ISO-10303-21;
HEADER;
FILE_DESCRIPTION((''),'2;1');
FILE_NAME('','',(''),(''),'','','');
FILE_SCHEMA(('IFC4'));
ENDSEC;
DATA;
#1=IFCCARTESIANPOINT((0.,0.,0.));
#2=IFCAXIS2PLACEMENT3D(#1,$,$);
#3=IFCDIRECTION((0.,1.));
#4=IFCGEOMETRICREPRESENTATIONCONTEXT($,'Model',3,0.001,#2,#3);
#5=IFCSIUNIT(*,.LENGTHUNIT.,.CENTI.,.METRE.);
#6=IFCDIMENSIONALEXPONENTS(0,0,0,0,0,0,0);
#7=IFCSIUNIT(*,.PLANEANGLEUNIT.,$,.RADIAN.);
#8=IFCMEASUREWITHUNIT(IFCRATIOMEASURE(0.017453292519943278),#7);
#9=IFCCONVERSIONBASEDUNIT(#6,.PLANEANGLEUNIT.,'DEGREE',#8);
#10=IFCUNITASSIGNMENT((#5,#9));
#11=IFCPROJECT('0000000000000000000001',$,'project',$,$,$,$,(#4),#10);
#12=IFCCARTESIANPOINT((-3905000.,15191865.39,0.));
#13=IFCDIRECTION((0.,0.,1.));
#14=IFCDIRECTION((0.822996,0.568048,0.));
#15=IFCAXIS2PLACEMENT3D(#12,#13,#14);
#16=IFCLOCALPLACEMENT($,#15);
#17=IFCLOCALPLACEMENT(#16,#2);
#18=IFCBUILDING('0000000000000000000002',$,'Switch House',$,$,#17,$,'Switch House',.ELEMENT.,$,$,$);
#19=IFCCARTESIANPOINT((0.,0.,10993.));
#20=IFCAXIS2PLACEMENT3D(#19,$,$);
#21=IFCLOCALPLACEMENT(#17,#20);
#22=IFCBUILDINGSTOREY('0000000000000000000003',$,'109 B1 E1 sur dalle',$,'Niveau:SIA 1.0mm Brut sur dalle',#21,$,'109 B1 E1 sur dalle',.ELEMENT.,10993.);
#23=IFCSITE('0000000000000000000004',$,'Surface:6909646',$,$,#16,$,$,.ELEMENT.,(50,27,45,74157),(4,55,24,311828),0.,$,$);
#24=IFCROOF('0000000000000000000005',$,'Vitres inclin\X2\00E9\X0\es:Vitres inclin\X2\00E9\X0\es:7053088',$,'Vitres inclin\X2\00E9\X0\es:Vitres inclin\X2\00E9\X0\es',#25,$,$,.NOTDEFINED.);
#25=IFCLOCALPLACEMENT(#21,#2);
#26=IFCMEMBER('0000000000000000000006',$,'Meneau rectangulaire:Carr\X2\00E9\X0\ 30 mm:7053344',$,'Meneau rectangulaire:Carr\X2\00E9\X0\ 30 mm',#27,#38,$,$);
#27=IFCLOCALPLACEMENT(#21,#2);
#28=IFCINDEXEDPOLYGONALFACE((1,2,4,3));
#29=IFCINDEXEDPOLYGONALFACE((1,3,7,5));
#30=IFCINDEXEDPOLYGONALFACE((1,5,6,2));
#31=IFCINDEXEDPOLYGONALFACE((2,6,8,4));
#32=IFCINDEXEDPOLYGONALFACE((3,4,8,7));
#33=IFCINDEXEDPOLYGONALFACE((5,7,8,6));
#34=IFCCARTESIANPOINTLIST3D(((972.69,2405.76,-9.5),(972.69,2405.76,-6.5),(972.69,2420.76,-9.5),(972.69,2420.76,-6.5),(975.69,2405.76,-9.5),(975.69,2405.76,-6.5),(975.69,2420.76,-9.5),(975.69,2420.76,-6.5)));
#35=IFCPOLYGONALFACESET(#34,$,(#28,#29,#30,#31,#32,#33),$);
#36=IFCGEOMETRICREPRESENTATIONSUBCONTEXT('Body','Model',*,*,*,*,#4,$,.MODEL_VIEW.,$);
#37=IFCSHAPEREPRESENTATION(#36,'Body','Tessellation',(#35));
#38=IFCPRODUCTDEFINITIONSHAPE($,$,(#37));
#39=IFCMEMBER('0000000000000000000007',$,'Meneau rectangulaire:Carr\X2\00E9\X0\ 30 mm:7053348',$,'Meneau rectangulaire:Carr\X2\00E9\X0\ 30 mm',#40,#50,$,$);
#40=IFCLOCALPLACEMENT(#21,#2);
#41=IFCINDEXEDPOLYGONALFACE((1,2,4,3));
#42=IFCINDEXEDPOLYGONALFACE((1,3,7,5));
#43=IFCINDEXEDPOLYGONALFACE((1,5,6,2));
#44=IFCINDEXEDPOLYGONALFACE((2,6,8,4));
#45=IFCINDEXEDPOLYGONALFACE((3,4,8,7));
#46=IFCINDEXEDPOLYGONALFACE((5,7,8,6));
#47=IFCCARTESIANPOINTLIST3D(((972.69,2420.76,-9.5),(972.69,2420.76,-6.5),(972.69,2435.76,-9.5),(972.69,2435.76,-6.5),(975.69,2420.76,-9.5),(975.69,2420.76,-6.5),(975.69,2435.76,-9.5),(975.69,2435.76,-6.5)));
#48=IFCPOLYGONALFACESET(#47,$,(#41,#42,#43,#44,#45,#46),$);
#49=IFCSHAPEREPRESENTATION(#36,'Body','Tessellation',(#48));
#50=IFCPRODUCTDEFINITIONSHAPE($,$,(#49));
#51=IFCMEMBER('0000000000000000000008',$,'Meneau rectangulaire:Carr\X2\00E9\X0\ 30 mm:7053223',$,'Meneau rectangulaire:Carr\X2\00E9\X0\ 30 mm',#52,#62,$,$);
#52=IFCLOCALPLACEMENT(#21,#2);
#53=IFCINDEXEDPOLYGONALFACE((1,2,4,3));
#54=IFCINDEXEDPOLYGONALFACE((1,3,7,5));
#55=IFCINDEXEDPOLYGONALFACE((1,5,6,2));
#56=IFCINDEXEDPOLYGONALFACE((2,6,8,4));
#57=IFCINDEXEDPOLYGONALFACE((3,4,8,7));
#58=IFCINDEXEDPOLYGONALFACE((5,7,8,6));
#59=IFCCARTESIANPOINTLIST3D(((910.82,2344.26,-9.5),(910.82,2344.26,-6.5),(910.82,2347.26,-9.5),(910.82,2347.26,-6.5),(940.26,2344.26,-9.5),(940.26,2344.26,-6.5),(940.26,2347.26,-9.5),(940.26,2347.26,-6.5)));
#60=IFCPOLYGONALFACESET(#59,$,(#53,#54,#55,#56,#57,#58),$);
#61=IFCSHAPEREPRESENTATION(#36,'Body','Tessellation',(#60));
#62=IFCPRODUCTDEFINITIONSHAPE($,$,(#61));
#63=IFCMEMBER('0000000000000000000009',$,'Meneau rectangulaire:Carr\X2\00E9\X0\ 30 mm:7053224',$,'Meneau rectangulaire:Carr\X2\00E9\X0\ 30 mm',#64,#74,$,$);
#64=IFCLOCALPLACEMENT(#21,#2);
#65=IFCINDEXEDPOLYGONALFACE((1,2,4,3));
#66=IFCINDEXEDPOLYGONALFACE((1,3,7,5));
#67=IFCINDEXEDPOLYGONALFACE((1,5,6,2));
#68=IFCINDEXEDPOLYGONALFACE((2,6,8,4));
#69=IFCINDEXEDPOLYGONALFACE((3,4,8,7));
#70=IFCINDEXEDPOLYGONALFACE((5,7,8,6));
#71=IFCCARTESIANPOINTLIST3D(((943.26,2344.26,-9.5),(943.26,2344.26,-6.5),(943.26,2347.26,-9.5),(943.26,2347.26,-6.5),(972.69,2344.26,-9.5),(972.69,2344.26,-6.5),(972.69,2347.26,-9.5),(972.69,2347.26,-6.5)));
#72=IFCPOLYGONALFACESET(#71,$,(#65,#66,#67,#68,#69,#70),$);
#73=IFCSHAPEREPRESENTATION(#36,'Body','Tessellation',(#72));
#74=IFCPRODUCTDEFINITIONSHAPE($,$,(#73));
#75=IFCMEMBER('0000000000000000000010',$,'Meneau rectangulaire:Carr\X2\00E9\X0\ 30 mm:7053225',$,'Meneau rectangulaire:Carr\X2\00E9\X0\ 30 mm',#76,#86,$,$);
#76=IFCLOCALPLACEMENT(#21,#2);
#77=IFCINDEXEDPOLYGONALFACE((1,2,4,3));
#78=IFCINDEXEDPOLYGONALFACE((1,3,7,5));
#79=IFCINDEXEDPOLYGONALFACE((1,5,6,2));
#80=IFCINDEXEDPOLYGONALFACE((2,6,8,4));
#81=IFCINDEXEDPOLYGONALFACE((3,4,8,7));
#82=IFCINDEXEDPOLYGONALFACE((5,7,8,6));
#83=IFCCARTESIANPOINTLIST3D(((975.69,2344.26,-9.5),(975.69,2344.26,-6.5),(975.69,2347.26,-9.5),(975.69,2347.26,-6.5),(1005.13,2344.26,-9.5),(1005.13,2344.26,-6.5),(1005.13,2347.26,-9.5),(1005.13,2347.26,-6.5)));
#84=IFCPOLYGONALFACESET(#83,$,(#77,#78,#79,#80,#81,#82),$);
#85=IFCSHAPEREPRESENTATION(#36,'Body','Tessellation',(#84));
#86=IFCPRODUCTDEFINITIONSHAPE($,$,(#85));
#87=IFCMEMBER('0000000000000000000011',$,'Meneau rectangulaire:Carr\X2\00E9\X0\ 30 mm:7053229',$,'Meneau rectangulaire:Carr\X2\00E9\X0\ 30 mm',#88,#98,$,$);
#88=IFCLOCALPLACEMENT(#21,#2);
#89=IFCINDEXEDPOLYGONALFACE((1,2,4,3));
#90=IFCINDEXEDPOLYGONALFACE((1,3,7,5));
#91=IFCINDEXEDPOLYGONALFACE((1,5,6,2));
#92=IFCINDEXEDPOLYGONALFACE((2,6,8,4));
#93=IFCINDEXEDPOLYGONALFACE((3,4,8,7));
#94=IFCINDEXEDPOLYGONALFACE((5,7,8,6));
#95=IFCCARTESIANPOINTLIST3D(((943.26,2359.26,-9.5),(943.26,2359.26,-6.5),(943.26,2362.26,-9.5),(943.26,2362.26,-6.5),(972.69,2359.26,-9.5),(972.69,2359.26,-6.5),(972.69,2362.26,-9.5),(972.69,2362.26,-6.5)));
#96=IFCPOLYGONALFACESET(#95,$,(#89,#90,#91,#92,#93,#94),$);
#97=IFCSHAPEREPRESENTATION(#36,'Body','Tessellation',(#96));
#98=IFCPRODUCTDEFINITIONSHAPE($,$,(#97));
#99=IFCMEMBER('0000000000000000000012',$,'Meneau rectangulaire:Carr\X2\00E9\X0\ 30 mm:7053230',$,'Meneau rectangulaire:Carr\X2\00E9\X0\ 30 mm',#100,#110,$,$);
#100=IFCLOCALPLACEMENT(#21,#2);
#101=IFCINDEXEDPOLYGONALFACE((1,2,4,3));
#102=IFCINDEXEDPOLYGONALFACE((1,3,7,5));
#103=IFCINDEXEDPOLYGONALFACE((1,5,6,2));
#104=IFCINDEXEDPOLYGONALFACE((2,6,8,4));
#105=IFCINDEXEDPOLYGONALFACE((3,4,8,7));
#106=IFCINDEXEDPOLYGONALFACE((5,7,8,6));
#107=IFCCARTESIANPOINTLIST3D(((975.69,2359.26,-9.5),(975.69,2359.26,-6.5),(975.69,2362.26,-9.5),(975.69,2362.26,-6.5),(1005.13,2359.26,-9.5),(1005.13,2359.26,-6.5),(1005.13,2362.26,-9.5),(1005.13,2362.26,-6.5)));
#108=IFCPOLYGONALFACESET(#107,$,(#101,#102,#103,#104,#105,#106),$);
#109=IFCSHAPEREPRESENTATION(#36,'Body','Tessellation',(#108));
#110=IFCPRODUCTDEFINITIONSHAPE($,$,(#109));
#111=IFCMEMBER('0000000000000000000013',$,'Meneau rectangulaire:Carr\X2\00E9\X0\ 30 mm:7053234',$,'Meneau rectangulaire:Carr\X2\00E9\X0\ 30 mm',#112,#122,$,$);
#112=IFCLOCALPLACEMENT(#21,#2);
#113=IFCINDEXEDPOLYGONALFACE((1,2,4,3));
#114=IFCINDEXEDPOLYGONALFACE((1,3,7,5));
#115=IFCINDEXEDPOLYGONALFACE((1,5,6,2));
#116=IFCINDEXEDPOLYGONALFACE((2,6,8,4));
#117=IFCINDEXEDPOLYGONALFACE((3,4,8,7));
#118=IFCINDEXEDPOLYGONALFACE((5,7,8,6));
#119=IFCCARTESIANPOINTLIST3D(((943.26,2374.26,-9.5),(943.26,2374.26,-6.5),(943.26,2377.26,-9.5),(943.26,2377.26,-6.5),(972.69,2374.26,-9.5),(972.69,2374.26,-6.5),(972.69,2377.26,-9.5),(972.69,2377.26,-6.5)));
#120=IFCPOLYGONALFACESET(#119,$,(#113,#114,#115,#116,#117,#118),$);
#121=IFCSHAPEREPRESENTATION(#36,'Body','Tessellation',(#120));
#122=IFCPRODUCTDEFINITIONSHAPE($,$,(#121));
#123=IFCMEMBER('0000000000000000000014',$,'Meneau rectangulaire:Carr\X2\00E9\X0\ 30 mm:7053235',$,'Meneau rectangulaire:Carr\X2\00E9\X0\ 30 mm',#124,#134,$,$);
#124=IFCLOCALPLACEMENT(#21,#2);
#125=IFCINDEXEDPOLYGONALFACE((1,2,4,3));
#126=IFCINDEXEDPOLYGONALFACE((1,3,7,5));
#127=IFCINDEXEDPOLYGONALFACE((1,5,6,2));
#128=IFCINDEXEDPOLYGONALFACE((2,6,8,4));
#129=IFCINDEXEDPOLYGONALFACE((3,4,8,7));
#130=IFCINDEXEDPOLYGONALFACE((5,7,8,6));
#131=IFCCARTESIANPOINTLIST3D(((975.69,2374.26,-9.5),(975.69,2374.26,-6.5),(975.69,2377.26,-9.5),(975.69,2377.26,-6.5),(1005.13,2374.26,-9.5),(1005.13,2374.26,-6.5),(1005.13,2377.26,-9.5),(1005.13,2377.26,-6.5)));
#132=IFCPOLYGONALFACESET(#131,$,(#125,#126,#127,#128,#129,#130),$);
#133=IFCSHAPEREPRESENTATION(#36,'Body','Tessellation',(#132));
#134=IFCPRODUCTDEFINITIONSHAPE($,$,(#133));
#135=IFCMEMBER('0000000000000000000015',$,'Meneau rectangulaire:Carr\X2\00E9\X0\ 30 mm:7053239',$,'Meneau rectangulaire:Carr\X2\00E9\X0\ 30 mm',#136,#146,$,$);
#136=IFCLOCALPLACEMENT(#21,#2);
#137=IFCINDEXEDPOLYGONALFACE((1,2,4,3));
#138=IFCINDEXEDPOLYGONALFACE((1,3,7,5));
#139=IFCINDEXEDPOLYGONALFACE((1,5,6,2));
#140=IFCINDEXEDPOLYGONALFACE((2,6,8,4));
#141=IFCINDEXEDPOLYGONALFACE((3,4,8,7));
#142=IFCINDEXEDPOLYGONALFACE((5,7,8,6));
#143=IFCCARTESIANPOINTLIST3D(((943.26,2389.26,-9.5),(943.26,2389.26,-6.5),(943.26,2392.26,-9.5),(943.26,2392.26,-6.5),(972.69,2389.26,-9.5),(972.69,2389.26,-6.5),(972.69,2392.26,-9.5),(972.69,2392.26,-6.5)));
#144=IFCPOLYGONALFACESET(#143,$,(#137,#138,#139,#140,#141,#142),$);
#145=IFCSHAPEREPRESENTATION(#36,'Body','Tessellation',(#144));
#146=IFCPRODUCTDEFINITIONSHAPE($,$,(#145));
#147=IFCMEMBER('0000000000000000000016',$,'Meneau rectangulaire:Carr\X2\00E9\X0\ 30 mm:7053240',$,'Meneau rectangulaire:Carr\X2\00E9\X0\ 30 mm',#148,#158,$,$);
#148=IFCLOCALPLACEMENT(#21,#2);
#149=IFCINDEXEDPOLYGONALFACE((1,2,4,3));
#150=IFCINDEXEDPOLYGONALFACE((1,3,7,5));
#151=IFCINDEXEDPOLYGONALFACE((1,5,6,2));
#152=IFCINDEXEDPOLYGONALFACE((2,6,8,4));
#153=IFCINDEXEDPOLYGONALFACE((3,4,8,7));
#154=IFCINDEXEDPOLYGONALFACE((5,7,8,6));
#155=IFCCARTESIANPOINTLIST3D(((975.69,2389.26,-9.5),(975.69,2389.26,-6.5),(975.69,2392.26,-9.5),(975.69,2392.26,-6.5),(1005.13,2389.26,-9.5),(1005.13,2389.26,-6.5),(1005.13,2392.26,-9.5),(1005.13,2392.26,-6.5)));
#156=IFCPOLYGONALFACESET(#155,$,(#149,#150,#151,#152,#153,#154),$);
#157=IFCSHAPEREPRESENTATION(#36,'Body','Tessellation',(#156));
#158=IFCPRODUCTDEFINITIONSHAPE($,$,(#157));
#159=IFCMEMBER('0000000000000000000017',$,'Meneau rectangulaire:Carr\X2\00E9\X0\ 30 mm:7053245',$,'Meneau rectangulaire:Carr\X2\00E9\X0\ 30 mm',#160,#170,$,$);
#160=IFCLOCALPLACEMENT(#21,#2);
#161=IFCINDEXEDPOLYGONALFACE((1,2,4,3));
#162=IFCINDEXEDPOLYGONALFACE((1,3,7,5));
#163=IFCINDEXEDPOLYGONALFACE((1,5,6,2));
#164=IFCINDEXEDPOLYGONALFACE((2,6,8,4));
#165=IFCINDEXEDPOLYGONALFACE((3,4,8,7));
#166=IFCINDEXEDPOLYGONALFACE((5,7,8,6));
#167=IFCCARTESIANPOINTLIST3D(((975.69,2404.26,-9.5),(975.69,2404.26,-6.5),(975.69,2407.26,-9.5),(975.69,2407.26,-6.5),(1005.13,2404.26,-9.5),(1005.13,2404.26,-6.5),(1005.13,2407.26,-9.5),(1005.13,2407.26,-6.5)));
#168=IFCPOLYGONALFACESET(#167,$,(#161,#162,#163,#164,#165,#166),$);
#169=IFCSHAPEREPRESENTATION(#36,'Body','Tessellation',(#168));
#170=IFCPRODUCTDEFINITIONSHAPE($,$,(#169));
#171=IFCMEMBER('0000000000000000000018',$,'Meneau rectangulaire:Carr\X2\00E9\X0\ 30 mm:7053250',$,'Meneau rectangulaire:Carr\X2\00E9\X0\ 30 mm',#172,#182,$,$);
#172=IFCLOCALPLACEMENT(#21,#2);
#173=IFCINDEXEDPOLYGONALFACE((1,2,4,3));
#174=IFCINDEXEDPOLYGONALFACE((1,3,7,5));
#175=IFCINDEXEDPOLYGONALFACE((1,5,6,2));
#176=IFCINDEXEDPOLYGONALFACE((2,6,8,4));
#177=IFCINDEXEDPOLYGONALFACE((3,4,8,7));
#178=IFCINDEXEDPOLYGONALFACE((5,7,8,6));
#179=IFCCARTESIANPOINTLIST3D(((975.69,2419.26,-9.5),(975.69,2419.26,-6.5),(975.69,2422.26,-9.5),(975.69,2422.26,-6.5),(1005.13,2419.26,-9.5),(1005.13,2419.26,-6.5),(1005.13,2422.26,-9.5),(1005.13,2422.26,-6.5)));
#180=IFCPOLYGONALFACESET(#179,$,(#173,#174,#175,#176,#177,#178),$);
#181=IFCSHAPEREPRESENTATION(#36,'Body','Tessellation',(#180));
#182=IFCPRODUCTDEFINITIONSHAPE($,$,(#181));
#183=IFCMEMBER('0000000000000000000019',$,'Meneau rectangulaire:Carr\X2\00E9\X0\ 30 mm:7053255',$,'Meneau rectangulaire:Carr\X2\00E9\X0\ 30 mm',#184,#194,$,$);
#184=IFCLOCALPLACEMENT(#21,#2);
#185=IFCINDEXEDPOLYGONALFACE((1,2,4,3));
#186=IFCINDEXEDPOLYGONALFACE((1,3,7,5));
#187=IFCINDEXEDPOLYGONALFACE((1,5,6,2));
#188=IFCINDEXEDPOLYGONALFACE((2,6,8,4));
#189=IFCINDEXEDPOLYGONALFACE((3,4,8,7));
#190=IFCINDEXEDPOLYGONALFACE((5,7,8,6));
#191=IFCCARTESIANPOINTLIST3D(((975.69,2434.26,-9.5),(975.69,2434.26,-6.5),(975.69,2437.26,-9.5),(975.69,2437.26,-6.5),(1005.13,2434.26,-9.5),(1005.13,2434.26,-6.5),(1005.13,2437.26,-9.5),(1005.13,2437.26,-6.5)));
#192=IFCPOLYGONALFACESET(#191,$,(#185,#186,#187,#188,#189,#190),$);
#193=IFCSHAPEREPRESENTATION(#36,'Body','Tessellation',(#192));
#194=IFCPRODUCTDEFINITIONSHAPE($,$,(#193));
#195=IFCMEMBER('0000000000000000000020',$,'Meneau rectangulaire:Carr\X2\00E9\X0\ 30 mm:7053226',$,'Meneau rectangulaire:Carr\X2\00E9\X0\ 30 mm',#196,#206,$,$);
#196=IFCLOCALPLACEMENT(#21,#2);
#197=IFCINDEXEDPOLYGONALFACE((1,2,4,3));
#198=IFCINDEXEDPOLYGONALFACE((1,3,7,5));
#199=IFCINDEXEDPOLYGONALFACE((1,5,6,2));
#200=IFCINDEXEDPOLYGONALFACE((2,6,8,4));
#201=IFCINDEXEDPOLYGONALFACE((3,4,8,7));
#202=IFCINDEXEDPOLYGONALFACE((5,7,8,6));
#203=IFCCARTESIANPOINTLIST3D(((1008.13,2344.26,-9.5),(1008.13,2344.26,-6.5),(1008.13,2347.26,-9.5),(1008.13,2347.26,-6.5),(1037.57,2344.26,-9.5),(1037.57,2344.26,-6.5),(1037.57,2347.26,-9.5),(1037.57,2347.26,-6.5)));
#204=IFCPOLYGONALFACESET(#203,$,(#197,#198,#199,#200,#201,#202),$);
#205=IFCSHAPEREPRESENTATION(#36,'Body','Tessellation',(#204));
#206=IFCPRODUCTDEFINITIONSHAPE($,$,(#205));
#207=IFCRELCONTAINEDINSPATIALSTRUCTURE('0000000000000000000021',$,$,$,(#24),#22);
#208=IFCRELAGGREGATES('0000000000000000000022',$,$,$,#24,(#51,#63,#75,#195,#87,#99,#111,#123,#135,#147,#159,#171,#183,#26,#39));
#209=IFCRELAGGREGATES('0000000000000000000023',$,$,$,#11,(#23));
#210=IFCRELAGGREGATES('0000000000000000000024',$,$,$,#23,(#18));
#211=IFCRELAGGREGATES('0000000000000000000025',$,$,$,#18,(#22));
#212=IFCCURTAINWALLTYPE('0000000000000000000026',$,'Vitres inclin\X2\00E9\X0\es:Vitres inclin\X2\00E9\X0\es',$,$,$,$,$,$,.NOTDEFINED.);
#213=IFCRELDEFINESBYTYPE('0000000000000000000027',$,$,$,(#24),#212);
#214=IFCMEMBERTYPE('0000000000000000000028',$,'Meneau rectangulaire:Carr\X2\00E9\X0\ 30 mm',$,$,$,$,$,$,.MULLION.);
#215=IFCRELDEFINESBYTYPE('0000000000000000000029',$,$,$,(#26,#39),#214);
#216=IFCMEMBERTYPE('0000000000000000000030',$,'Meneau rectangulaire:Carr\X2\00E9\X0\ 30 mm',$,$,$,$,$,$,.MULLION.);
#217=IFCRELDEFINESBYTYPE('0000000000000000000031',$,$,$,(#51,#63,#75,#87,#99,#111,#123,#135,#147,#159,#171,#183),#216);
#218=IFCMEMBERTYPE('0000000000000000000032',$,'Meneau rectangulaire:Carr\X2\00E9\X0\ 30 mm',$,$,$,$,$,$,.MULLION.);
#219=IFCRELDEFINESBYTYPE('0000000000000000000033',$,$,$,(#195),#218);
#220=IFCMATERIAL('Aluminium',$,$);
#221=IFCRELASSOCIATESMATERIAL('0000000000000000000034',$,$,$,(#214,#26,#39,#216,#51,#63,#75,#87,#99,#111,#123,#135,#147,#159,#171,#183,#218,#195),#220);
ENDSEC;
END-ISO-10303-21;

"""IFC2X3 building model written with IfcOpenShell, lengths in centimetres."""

from ifc_helpers import new_model, entity, si_unit, converted_unit, direction, frame, origin, origin_2d_with_axis, place, context, subcontext, project, spatial, rectangle, extrude, source, transform, mapped, material, type_object, type_shapes, element, aggregate, save


model = new_model("IFC2X3")

# Units and contexts
model_context = context("Model", 3, precision=0.001, world=origin(), true_north=direction((0.0, 1.0)))
body_context = subcontext(model_context, "Body", "Model", "MODEL_VIEW")
ifc_project = project(units=[si_unit("LENGTHUNIT", "METRE", prefix="CENTI"), converted_unit("PLANEANGLEUNIT", "DEGREE", entity("IfcRatioMeasure", 0.017453292519943278), si_unit("PLANEANGLEUNIT", "RADIAN"), dimensions=[0, 0, 0, 0, 0, 0, 0])], contexts=[model_context])

# Site, building, storey
site_placement = place(None, frame((-3905000.0, 15191865.39, 0.0), z_axis=(0.0, 0.0, 1.0), x_axis=(0.822996, 0.568048, 0.0)))
site = spatial("IfcSite", under=ifc_project, at=site_placement, Name="Surface:6909646", CompositionType="ELEMENT", RefLatitude=(50, 27, 45, 74157), RefLongitude=(4, 55, 24, 311828), RefElevation=0.0)
building_placement = place(site_placement, origin())
building = spatial("IfcBuilding", under=site, at=building_placement, Name="Switch House", LongName="Switch House", CompositionType="ELEMENT")
storey_placement = place(building_placement, frame((0.0, 0.0, 10993.0)))
storey = spatial("IfcBuildingStorey", under=building, at=storey_placement, Name="109 B1 E1 sur dalle", ObjectType="Niveau:SIA 1.0mm Brut sur dalle", LongName="109 B1 E1 sur dalle", CompositionType="ELEMENT", Elevation=10993.0)

# Roof, members
curtain_wall_type = type_object("IfcCurtainWallType", Name="Vitres inclinées:Vitres inclinées", PredefinedType="NOTDEFINED")
roof_placement = place(storey_placement, frame((0.0, 0.0, -10993.0)))
roof = element("IfcRoof", 1, at=roof_placement, inside=storey, type_object=curtain_wall_type, Name="Vitres inclinées:Vitres inclinées:7053088", ObjectType="Vitres inclinées:Vitres inclinées", ShapeType="NOTDEFINED")
ifc_material = material(Name="Aluminium")
member_type_1 = type_object("IfcMemberType", Name="Meneau rectangulaire:Carré 30 mm", PredefinedType="MULLION", material=ifc_material)
shared_shape_1 = source(origin(), body_context, "Body", "SweptSolid", [
    extrude(rectangle(XDim=3.0, YDim=3.0, at=origin_2d_with_axis()), frame((0.0, 0.0, -15.0), z_axis=(0.0, 0.0, 1.0), x_axis=(0.0, -1.0, 0.0)), (0.0, 0.0, 1.0), 15.0),
])
type_shapes(member_type_1, [shared_shape_1])
member_1_placement = place(roof_placement, frame((974.19, 2420.76, 10985.0), z_axis=(0.0, 1.0, 0.0), x_axis=(1.0, 0.0, 0.0)))
member_1 = element("IfcMember", 2, at=member_1_placement, type_object=member_type_1, material=ifc_material, Name="Meneau rectangulaire:Carré 30 mm:7053344", ObjectType="Meneau rectangulaire:Carré 30 mm", context=body_context, shape_type="MappedRepresentation", body=[
    mapped(shared_shape_1, transform((0.0, 0.0, 0.0), scale=1.0)),
])
member_2_placement = place(roof_placement, frame((974.19, 2435.76, 10985.0), z_axis=(0.0, 1.0, 0.0), x_axis=(1.0, 0.0, 0.0)))
member_2 = element("IfcMember", 3, at=member_2_placement, type_object=member_type_1, material=ifc_material, Name="Meneau rectangulaire:Carré 30 mm:7053348", ObjectType="Meneau rectangulaire:Carré 30 mm", context=body_context, shape_type="MappedRepresentation", body=[
    mapped(shared_shape_1, transform((0.0, 0.0, 0.0), scale=1.0)),
])
member_type_2 = type_object("IfcMemberType", Name="Meneau rectangulaire:Carré 30 mm", PredefinedType="MULLION", material=ifc_material)
shared_shape_2 = source(origin(), body_context, "Body", "SweptSolid", [
    extrude(rectangle(XDim=3.0, YDim=3.0, at=origin_2d_with_axis()), frame((0.0, 0.0, -29.44), z_axis=(0.0, 0.0, 1.0), x_axis=(0.0, -1.0, 0.0)), (0.0, 0.0, 1.0), 29.44),
])
type_shapes(member_type_2, [shared_shape_2])
member_3_placement = place(roof_placement, frame((910.82, 2345.76, 10985.0), z_axis=(-1.0, 0.0, 0.0), x_axis=(0.0, 1.0, 0.0)))
member_3 = element("IfcMember", 4, at=member_3_placement, type_object=member_type_2, material=ifc_material, Name="Meneau rectangulaire:Carré 30 mm:7053223", ObjectType="Meneau rectangulaire:Carré 30 mm", context=body_context, shape_type="MappedRepresentation", body=[
    mapped(shared_shape_2, transform((0.0, 0.0, 0.0), scale=1.0)),
])
member_4_placement = place(roof_placement, frame((943.26, 2345.76, 10985.0), z_axis=(-1.0, 0.0, 0.0), x_axis=(0.0, 1.0, 0.0)))
member_4 = element("IfcMember", 5, at=member_4_placement, type_object=member_type_2, material=ifc_material, Name="Meneau rectangulaire:Carré 30 mm:7053224", ObjectType="Meneau rectangulaire:Carré 30 mm", context=body_context, shape_type="MappedRepresentation", body=[
    mapped(shared_shape_2, transform((0.0, 0.0, 0.0), scale=1.0)),
])
member_5_placement = place(roof_placement, frame((975.69, 2345.76, 10985.0), z_axis=(-1.0, 0.0, 0.0), x_axis=(0.0, 1.0, 0.0)))
member_5 = element("IfcMember", 6, at=member_5_placement, type_object=member_type_2, material=ifc_material, Name="Meneau rectangulaire:Carré 30 mm:7053225", ObjectType="Meneau rectangulaire:Carré 30 mm", context=body_context, shape_type="MappedRepresentation", body=[
    mapped(shared_shape_2, transform((0.0, 0.0, 0.0), scale=1.0)),
])
member_6_placement = place(roof_placement, frame((943.26, 2360.76, 10985.0), z_axis=(-1.0, 0.0, 0.0), x_axis=(0.0, 1.0, 0.0)))
member_6 = element("IfcMember", 7, at=member_6_placement, type_object=member_type_2, material=ifc_material, Name="Meneau rectangulaire:Carré 30 mm:7053229", ObjectType="Meneau rectangulaire:Carré 30 mm", context=body_context, shape_type="MappedRepresentation", body=[
    mapped(shared_shape_2, transform((0.0, 0.0, 0.0), scale=1.0)),
])
member_7_placement = place(roof_placement, frame((975.69, 2360.76, 10985.0), z_axis=(-1.0, 0.0, 0.0), x_axis=(0.0, 1.0, 0.0)))
member_7 = element("IfcMember", 8, at=member_7_placement, type_object=member_type_2, material=ifc_material, Name="Meneau rectangulaire:Carré 30 mm:7053230", ObjectType="Meneau rectangulaire:Carré 30 mm", context=body_context, shape_type="MappedRepresentation", body=[
    mapped(shared_shape_2, transform((0.0, 0.0, 0.0), scale=1.0)),
])
member_8_placement = place(roof_placement, frame((943.26, 2375.76, 10985.0), z_axis=(-1.0, 0.0, 0.0), x_axis=(0.0, 1.0, 0.0)))
member_8 = element("IfcMember", 9, at=member_8_placement, type_object=member_type_2, material=ifc_material, Name="Meneau rectangulaire:Carré 30 mm:7053234", ObjectType="Meneau rectangulaire:Carré 30 mm", context=body_context, shape_type="MappedRepresentation", body=[
    mapped(shared_shape_2, transform((0.0, 0.0, 0.0), scale=1.0)),
])
member_9_placement = place(roof_placement, frame((975.69, 2375.76, 10985.0), z_axis=(-1.0, 0.0, 0.0), x_axis=(0.0, 1.0, 0.0)))
member_9 = element("IfcMember", 10, at=member_9_placement, type_object=member_type_2, material=ifc_material, Name="Meneau rectangulaire:Carré 30 mm:7053235", ObjectType="Meneau rectangulaire:Carré 30 mm", context=body_context, shape_type="MappedRepresentation", body=[
    mapped(shared_shape_2, transform((0.0, 0.0, 0.0), scale=1.0)),
])
member_10_placement = place(roof_placement, frame((943.26, 2390.76, 10985.0), z_axis=(-1.0, 0.0, 0.0), x_axis=(0.0, 1.0, 0.0)))
member_10 = element("IfcMember", 11, at=member_10_placement, type_object=member_type_2, material=ifc_material, Name="Meneau rectangulaire:Carré 30 mm:7053239", ObjectType="Meneau rectangulaire:Carré 30 mm", context=body_context, shape_type="MappedRepresentation", body=[
    mapped(shared_shape_2, transform((0.0, 0.0, 0.0), scale=1.0)),
])
member_11_placement = place(roof_placement, frame((975.69, 2390.76, 10985.0), z_axis=(-1.0, 0.0, 0.0), x_axis=(0.0, 1.0, 0.0)))
member_11 = element("IfcMember", 12, at=member_11_placement, type_object=member_type_2, material=ifc_material, Name="Meneau rectangulaire:Carré 30 mm:7053240", ObjectType="Meneau rectangulaire:Carré 30 mm", context=body_context, shape_type="MappedRepresentation", body=[
    mapped(shared_shape_2, transform((0.0, 0.0, 0.0), scale=1.0)),
])
member_12_placement = place(roof_placement, frame((975.69, 2405.76, 10985.0), z_axis=(-1.0, 0.0, 0.0), x_axis=(0.0, 1.0, 0.0)))
member_12 = element("IfcMember", 13, at=member_12_placement, type_object=member_type_2, material=ifc_material, Name="Meneau rectangulaire:Carré 30 mm:7053245", ObjectType="Meneau rectangulaire:Carré 30 mm", context=body_context, shape_type="MappedRepresentation", body=[
    mapped(shared_shape_2, transform((0.0, 0.0, 0.0), scale=1.0)),
])
member_13_placement = place(roof_placement, frame((975.69, 2420.76, 10985.0), z_axis=(-1.0, 0.0, 0.0), x_axis=(0.0, 1.0, 0.0)))
member_13 = element("IfcMember", 14, at=member_13_placement, type_object=member_type_2, material=ifc_material, Name="Meneau rectangulaire:Carré 30 mm:7053250", ObjectType="Meneau rectangulaire:Carré 30 mm", context=body_context, shape_type="MappedRepresentation", body=[
    mapped(shared_shape_2, transform((0.0, 0.0, 0.0), scale=1.0)),
])
member_14_placement = place(roof_placement, frame((975.69, 2435.76, 10985.0), z_axis=(-1.0, 0.0, 0.0), x_axis=(0.0, 1.0, 0.0)))
member_14 = element("IfcMember", 15, at=member_14_placement, type_object=member_type_2, material=ifc_material, Name="Meneau rectangulaire:Carré 30 mm:7053255", ObjectType="Meneau rectangulaire:Carré 30 mm", context=body_context, shape_type="MappedRepresentation", body=[
    mapped(shared_shape_2, transform((0.0, 0.0, 0.0), scale=1.0)),
])
member_type_3 = type_object("IfcMemberType", Name="Meneau rectangulaire:Carré 30 mm", PredefinedType="MULLION", material=ifc_material)
shared_shape_3 = source(origin(), body_context, "Body", "SweptSolid", [
    extrude(rectangle(XDim=3.0, YDim=3.0, at=origin_2d_with_axis()), frame((0.0, 0.0, -29.44), z_axis=(0.0, 0.0, 1.0), x_axis=(0.0, -1.0, 0.0)), (0.0, 0.0, 1.0), 29.44),
])
type_shapes(member_type_3, [shared_shape_3])
member_15_placement = place(roof_placement, frame((1008.13, 2345.76, 10985.0), z_axis=(-1.0, 0.0, 0.0), x_axis=(0.0, 1.0, 0.0)))
member_15 = element("IfcMember", 16, at=member_15_placement, type_object=member_type_3, material=ifc_material, Name="Meneau rectangulaire:Carré 30 mm:7053226", ObjectType="Meneau rectangulaire:Carré 30 mm", context=body_context, shape_type="MappedRepresentation", body=[
    mapped(shared_shape_3, transform((0.0, 0.0, 0.0), scale=1.0)),
])
aggregate(roof, [member_3, member_4, member_5, member_15, member_6, member_7, member_8, member_9, member_10, member_11, member_12, member_13, member_14, member_1, member_2])

save(model, "model.ifc")
